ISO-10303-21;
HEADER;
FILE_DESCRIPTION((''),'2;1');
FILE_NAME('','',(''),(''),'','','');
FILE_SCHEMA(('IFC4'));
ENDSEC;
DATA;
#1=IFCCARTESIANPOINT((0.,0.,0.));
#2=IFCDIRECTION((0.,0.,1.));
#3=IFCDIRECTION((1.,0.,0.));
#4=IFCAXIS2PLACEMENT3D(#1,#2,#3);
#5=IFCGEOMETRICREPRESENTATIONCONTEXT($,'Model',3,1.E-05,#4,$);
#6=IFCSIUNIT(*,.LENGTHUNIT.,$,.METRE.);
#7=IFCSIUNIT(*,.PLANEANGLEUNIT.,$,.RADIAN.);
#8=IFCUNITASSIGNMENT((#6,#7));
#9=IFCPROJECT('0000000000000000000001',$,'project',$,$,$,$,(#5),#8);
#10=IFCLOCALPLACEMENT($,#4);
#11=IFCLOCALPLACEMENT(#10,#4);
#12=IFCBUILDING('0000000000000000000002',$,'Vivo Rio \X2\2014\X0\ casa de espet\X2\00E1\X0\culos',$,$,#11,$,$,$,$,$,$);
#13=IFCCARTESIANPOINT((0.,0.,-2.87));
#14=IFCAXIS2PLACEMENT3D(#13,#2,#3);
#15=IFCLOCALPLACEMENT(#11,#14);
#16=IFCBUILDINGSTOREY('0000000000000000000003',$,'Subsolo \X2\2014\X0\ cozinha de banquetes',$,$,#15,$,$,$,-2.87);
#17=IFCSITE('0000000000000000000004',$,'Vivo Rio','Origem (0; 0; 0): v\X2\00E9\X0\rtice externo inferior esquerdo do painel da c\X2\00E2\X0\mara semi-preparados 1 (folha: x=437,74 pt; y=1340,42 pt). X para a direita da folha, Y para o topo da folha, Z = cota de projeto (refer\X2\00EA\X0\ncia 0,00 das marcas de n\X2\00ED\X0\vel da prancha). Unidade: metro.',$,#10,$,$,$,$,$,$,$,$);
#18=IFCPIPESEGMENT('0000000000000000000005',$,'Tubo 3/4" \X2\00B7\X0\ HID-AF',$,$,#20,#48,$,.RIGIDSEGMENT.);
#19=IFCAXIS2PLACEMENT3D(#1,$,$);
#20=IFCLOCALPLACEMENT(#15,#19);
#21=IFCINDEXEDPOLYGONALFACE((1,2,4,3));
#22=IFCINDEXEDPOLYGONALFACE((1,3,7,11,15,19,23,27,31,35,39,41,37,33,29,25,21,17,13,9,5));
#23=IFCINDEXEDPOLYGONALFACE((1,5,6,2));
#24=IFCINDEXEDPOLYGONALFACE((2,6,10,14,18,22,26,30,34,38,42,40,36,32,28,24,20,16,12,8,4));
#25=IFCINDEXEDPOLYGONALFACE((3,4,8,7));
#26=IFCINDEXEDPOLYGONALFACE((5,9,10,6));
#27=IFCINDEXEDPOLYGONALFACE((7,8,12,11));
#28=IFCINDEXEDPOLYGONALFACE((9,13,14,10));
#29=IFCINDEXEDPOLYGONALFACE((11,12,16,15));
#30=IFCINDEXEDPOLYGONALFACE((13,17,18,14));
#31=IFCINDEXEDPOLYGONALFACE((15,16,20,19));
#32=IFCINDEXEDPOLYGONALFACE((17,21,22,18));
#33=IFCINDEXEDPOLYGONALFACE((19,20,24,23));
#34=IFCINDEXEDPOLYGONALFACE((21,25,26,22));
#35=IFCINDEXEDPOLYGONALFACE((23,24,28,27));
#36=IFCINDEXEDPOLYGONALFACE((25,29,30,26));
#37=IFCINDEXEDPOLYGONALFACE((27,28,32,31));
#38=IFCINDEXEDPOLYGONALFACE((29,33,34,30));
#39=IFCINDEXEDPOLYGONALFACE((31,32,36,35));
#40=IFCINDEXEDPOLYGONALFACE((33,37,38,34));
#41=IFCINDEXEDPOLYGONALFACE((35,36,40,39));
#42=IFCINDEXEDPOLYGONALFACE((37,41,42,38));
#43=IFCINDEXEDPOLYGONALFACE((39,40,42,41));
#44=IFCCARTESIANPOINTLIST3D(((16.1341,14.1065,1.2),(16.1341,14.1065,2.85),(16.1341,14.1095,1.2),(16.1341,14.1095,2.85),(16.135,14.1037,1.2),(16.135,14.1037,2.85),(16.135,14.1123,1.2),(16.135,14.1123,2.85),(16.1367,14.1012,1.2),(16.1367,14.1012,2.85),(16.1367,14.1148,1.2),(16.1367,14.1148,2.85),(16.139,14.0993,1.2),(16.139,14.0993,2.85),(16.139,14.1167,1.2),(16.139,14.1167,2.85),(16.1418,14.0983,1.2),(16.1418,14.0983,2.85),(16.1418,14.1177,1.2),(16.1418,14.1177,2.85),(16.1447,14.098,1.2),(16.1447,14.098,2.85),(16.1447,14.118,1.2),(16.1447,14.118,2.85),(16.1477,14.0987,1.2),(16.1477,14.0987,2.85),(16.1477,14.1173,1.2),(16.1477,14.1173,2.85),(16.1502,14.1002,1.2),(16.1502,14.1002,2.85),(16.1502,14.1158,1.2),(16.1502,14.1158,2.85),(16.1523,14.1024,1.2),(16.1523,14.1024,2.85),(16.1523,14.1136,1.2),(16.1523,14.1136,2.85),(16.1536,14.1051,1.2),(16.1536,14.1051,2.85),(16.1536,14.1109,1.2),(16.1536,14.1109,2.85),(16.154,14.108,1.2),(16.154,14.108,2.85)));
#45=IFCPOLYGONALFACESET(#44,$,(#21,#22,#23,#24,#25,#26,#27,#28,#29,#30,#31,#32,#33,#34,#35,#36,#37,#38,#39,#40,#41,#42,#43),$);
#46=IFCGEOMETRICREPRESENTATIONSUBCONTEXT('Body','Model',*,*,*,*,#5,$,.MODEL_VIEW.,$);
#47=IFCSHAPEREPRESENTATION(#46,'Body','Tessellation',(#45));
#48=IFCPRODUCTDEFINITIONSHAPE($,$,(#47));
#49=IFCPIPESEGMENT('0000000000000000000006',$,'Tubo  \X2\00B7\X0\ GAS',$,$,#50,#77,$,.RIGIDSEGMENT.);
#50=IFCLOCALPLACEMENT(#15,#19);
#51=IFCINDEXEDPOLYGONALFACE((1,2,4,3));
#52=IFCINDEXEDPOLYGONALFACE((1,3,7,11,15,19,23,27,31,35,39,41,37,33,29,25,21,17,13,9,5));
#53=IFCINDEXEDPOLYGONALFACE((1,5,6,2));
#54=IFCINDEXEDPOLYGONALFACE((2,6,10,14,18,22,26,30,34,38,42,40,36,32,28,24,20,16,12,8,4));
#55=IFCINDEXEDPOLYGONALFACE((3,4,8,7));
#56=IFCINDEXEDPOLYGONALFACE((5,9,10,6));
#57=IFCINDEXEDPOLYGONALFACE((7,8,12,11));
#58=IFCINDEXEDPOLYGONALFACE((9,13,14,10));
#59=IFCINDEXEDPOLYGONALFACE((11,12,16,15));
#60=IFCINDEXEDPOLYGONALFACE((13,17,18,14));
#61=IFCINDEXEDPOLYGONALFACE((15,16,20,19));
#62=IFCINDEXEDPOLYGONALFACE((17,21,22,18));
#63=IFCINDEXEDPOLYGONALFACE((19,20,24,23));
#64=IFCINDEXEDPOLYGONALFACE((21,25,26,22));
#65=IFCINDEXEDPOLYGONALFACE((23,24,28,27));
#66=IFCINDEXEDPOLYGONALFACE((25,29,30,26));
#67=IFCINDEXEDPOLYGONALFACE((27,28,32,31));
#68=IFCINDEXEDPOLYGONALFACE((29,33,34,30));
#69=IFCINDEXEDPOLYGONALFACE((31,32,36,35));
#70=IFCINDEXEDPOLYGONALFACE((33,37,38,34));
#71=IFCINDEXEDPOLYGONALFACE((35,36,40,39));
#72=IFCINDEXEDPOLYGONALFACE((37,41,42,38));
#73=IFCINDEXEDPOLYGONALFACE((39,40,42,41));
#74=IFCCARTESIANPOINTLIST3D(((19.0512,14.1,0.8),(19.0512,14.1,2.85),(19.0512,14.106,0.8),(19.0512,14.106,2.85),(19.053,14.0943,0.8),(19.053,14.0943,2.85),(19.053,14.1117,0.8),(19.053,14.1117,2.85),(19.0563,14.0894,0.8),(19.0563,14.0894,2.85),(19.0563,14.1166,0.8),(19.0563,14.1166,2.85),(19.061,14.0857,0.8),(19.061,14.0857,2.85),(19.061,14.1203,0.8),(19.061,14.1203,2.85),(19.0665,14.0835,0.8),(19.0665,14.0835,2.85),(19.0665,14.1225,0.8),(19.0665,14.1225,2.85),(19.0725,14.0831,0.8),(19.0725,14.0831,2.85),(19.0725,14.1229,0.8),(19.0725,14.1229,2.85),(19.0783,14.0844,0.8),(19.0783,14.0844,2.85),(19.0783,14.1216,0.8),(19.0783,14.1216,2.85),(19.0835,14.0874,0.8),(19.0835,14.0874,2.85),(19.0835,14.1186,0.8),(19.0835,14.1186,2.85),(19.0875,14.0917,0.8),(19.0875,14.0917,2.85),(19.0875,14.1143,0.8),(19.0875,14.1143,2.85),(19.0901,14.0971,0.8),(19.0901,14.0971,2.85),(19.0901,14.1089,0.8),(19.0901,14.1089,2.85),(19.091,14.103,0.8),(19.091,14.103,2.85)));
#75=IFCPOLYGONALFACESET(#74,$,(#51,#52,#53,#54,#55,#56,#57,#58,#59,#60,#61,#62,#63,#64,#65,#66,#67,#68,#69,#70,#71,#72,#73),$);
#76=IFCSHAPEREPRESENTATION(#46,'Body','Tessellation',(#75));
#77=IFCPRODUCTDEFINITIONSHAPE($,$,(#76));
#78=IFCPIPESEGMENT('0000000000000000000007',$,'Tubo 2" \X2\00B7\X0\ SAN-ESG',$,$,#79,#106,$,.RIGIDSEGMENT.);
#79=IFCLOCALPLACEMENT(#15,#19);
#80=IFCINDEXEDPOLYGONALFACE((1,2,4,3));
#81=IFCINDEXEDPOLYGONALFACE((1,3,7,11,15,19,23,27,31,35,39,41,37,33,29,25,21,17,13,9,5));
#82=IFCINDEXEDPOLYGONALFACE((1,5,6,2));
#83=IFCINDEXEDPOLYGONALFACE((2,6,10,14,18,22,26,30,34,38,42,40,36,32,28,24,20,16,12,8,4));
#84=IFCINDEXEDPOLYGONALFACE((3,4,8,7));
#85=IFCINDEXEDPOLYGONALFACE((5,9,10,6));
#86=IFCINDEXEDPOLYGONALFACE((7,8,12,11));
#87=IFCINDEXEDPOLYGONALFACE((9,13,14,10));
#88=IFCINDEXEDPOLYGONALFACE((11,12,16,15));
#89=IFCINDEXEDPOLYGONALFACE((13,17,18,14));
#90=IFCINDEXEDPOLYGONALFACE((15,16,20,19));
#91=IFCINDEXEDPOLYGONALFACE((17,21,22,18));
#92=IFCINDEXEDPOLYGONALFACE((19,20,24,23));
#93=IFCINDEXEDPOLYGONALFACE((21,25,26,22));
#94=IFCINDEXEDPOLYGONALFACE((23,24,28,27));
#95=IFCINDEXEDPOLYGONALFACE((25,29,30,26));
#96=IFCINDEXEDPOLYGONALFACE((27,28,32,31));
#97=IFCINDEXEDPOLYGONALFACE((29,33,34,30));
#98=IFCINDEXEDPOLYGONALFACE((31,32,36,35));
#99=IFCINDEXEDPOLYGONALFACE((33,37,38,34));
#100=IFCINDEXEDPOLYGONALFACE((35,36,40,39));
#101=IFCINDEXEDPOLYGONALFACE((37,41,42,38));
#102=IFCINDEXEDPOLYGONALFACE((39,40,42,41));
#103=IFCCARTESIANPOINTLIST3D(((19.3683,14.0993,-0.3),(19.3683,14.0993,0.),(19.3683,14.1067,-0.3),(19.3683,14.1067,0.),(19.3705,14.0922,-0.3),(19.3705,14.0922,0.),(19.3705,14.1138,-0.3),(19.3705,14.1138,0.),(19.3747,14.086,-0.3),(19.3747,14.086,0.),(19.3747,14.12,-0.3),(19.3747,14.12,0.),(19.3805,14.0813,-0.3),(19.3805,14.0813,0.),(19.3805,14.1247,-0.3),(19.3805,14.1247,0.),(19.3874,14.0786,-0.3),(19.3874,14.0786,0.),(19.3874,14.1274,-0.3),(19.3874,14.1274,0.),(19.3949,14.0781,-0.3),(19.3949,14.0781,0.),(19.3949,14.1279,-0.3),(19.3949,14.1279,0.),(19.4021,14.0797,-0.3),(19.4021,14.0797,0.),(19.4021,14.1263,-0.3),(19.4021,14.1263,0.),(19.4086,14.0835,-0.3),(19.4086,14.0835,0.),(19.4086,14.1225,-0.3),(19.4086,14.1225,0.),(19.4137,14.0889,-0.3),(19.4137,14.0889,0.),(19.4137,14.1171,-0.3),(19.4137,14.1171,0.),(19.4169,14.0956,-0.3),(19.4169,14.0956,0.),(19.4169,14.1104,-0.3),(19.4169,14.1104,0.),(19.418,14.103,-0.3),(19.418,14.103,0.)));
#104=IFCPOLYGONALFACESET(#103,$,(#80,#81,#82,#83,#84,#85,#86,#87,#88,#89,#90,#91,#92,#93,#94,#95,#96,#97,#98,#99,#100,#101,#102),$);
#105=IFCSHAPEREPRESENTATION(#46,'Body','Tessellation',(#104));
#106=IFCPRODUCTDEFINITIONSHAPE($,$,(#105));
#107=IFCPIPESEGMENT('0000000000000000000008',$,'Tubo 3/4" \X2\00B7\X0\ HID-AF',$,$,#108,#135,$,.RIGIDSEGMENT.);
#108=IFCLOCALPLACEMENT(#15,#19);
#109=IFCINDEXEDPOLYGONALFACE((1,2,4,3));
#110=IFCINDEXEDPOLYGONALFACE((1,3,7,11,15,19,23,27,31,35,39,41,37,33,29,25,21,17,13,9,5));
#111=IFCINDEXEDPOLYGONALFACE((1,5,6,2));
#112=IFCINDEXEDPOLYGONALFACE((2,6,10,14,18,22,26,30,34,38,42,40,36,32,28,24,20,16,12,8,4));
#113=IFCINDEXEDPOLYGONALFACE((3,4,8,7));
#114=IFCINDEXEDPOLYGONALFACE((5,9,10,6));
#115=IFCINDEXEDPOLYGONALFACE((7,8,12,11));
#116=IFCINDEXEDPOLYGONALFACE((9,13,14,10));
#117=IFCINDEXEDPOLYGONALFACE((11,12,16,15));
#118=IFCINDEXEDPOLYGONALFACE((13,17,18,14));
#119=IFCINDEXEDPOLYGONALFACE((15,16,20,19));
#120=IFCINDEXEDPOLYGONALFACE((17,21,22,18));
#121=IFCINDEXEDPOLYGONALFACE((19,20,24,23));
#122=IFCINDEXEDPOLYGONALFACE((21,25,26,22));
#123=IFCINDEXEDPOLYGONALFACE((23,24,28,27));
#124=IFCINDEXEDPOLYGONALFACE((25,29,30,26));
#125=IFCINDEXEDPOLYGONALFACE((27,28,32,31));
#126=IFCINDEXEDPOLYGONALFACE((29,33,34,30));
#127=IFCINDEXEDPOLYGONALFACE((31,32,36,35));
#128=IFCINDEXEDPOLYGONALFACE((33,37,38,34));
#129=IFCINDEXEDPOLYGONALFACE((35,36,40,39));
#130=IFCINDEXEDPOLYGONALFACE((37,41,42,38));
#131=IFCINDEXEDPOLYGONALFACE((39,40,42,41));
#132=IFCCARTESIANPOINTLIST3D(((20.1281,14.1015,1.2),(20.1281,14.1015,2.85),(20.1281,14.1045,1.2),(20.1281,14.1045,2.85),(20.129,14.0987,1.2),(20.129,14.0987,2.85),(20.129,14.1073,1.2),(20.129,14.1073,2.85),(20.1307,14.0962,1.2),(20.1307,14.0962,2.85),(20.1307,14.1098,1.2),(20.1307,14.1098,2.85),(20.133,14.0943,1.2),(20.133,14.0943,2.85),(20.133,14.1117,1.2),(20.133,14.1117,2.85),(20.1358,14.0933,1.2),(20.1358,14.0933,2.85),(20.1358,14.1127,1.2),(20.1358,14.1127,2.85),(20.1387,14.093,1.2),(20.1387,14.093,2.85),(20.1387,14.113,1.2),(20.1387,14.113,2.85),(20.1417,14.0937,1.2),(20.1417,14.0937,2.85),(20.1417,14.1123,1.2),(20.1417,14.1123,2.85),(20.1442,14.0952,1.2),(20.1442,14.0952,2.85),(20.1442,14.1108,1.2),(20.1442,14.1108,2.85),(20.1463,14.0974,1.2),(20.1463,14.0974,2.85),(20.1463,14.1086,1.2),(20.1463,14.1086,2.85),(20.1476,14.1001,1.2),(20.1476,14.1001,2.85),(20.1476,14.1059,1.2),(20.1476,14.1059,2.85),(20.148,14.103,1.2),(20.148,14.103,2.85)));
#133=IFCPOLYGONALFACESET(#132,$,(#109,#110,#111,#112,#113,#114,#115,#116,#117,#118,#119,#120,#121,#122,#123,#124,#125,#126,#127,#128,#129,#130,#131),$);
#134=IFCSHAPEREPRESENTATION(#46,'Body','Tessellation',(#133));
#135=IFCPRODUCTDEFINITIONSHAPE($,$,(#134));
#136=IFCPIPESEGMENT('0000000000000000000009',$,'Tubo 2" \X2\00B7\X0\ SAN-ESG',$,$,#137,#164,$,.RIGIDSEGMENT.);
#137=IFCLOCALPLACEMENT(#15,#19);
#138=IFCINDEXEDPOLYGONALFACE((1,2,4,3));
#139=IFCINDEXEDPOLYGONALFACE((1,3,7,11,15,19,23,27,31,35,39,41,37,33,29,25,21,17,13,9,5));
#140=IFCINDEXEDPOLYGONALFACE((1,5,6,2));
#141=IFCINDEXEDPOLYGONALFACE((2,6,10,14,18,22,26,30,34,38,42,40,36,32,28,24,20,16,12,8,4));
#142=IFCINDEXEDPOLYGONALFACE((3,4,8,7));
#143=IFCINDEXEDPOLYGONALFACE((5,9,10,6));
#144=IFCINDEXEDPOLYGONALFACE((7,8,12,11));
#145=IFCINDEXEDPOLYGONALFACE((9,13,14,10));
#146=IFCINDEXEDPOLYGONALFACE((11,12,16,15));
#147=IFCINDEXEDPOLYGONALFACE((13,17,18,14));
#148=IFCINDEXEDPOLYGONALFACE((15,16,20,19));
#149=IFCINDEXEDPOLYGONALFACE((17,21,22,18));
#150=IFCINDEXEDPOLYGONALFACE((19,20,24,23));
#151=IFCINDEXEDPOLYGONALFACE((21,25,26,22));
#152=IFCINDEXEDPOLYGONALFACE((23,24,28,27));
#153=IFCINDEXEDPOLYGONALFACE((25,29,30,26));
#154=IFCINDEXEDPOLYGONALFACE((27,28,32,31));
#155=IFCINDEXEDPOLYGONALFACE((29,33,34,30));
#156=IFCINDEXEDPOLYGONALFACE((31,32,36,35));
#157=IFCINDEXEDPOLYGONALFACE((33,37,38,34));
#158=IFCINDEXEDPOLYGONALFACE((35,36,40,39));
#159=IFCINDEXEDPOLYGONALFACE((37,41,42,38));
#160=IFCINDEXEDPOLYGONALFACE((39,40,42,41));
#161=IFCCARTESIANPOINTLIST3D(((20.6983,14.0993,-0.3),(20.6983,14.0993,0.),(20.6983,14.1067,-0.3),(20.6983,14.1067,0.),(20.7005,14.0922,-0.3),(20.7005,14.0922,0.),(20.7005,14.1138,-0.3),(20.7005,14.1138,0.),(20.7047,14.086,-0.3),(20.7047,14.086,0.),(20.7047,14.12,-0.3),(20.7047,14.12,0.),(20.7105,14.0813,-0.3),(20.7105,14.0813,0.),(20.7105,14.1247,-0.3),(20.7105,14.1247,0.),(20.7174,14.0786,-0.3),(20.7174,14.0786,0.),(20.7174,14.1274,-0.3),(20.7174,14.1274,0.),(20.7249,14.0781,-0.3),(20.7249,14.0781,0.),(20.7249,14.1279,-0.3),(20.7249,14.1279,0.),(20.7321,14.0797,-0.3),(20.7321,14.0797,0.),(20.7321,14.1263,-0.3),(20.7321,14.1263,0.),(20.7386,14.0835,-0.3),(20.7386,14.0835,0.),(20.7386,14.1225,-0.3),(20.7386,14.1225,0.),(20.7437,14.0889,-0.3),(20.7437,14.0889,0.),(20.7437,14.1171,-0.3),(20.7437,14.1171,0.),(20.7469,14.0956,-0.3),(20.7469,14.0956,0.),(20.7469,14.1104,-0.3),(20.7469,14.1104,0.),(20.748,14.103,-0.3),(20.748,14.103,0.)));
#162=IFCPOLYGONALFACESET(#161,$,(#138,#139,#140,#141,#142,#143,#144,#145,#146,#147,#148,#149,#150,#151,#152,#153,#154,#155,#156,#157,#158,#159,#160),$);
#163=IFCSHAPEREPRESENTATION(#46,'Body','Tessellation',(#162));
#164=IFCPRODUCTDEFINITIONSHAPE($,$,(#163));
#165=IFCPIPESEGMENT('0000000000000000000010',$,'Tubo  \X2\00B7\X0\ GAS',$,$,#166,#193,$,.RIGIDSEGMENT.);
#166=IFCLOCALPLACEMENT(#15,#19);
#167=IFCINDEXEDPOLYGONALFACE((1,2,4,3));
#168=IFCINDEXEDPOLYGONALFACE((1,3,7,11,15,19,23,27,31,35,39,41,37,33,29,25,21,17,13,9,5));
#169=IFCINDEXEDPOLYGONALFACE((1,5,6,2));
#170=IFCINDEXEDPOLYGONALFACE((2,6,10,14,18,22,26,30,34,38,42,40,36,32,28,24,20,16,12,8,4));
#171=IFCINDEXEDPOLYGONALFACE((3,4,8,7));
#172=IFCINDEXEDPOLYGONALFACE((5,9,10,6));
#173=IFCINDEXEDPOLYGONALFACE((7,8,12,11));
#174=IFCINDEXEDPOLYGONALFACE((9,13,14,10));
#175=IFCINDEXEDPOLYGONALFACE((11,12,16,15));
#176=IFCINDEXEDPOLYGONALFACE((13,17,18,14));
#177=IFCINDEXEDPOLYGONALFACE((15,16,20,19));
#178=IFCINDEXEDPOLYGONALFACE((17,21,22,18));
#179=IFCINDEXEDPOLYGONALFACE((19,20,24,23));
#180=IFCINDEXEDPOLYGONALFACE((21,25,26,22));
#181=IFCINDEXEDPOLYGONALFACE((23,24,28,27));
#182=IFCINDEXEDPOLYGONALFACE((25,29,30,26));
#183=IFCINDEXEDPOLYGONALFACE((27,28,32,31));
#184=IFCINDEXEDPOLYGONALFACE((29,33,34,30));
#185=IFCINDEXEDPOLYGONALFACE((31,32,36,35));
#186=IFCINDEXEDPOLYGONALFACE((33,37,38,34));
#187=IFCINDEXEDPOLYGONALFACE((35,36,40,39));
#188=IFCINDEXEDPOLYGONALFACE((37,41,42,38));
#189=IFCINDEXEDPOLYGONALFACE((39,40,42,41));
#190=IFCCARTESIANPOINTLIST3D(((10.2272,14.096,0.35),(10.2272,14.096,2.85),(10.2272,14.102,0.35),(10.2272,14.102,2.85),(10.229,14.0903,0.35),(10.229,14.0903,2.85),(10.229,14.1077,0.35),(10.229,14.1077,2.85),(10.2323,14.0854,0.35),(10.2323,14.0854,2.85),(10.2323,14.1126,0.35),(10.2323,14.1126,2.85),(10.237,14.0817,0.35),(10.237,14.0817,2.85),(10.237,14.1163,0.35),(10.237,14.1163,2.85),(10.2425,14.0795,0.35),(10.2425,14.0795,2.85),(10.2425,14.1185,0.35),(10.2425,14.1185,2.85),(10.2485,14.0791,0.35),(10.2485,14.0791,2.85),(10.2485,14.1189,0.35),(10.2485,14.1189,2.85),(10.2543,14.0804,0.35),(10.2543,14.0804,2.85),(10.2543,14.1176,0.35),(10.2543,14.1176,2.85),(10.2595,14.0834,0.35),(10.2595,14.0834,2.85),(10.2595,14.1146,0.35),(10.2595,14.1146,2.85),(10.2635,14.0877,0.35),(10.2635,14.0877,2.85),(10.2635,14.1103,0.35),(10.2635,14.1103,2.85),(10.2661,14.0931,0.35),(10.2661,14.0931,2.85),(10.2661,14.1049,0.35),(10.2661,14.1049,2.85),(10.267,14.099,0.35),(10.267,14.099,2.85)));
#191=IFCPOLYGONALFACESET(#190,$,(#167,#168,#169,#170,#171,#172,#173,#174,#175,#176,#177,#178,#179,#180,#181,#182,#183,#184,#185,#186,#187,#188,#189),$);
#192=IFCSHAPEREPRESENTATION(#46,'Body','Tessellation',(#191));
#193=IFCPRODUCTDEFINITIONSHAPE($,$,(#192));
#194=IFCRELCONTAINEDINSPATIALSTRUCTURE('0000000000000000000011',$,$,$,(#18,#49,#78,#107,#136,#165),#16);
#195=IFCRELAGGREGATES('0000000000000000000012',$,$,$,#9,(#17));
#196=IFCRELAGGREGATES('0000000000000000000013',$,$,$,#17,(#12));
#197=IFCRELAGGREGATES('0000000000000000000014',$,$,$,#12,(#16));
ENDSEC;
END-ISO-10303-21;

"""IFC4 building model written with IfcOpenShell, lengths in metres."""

from ifc_helpers import new_model, si_unit, frame, origin_with_axes, origin_2d, place, context, subcontext, project, spatial, circle, extrude, element, save


model = new_model("IFC4")

# Units and contexts
model_context = context("Model", 3, precision=1e-05, world=origin_with_axes())
body_context = subcontext(model_context, "Body", "Model", "MODEL_VIEW")
ifc_project = project(units=[si_unit("LENGTHUNIT", "METRE"), si_unit("PLANEANGLEUNIT", "RADIAN")], contexts=[model_context])

# Site, building, storey
site_placement = place(None, origin_with_axes())
site = spatial("IfcSite", under=ifc_project, at=site_placement, Name="Vivo Rio", Description="Origem (0; 0; 0): vértice externo inferior esquerdo do painel da câmara semi-preparados 1 (folha: x=437,74 pt; y=1340,42 pt). X para a direita da folha, Y para o topo da folha, Z = cota de projeto (referência 0,00 das marcas de nível da prancha). Unidade: metro.")
building_placement = place(site_placement, origin_with_axes())
building = spatial("IfcBuilding", under=site, at=building_placement, Name="Vivo Rio — casa de espetáculos")
storey_placement = place(building_placement, frame((0.0, 0.0, -2.87), z_axis=(0.0, 0.0, 1.0), x_axis=(1.0, 0.0, 0.0)))
storey = spatial("IfcBuildingStorey", under=building, at=storey_placement, Name="Subsolo — cozinha de banquetes", Elevation=-2.87)

# Pipe segments
pipe_segment_1_placement = place(storey_placement, origin_with_axes())
element("IfcPipeSegment", 1, at=pipe_segment_1_placement, inside=storey, Name="Tubo 3/4\" · HID-AF", PredefinedType="RIGIDSEGMENT", context=body_context, shape_type="SweptSolid", body=[
    extrude(circle(Radius=0.01, at=origin_2d()), frame((16.144, 14.108, 2.85), z_axis=(0.0, 0.0, -1.0), x_axis=(1.0, 0.0, 0.0)), (0.0, 0.0, 1.0), 1.65),
])
pipe_segment_2_placement = place(storey_placement, origin_with_axes())
element("IfcPipeSegment", 2, at=pipe_segment_2_placement, inside=storey, Name="Tubo  · GAS", PredefinedType="RIGIDSEGMENT", context=body_context, shape_type="SweptSolid", body=[
    extrude(circle(Radius=0.02, at=origin_2d()), frame((19.071, 14.103, 2.85), z_axis=(0.0, 0.0, -1.0), x_axis=(1.0, 0.0, 0.0)), (0.0, 0.0, 1.0), 2.05),
])
pipe_segment_3_placement = place(storey_placement, origin_with_axes())
element("IfcPipeSegment", 3, at=pipe_segment_3_placement, inside=storey, Name="Tubo 2\" · SAN-ESG", PredefinedType="RIGIDSEGMENT", context=body_context, shape_type="SweptSolid", body=[
    extrude(circle(Radius=0.025, at=origin_2d()), frame((19.393, 14.103, 0.0), z_axis=(0.0, 0.0, -1.0), x_axis=(1.0, 0.0, 0.0)), (0.0, 0.0, 1.0), 0.3),
])
pipe_segment_4_placement = place(storey_placement, origin_with_axes())
element("IfcPipeSegment", 4, at=pipe_segment_4_placement, inside=storey, Name="Tubo 3/4\" · HID-AF", PredefinedType="RIGIDSEGMENT", context=body_context, shape_type="SweptSolid", body=[
    extrude(circle(Radius=0.01, at=origin_2d()), frame((20.138, 14.103, 2.85), z_axis=(0.0, 0.0, -1.0), x_axis=(1.0, 0.0, 0.0)), (0.0, 0.0, 1.0), 1.65),
])
pipe_segment_5_placement = place(storey_placement, origin_with_axes())
element("IfcPipeSegment", 5, at=pipe_segment_5_placement, inside=storey, Name="Tubo 2\" · SAN-ESG", PredefinedType="RIGIDSEGMENT", context=body_context, shape_type="SweptSolid", body=[
    extrude(circle(Radius=0.025, at=origin_2d()), frame((20.723, 14.103, 0.0), z_axis=(0.0, 0.0, -1.0), x_axis=(1.0, 0.0, 0.0)), (0.0, 0.0, 1.0), 0.3),
])
pipe_segment_6_placement = place(storey_placement, origin_with_axes())
element("IfcPipeSegment", 6, at=pipe_segment_6_placement, inside=storey, Name="Tubo  · GAS", PredefinedType="RIGIDSEGMENT", context=body_context, shape_type="SweptSolid", body=[
    extrude(circle(Radius=0.02, at=origin_2d()), frame((10.247, 14.099, 2.85), z_axis=(0.0, 0.0, -1.0), x_axis=(1.0, 0.0, 0.0)), (0.0, 0.0, 1.0), 2.5),
])

save(model, "model.ifc")
